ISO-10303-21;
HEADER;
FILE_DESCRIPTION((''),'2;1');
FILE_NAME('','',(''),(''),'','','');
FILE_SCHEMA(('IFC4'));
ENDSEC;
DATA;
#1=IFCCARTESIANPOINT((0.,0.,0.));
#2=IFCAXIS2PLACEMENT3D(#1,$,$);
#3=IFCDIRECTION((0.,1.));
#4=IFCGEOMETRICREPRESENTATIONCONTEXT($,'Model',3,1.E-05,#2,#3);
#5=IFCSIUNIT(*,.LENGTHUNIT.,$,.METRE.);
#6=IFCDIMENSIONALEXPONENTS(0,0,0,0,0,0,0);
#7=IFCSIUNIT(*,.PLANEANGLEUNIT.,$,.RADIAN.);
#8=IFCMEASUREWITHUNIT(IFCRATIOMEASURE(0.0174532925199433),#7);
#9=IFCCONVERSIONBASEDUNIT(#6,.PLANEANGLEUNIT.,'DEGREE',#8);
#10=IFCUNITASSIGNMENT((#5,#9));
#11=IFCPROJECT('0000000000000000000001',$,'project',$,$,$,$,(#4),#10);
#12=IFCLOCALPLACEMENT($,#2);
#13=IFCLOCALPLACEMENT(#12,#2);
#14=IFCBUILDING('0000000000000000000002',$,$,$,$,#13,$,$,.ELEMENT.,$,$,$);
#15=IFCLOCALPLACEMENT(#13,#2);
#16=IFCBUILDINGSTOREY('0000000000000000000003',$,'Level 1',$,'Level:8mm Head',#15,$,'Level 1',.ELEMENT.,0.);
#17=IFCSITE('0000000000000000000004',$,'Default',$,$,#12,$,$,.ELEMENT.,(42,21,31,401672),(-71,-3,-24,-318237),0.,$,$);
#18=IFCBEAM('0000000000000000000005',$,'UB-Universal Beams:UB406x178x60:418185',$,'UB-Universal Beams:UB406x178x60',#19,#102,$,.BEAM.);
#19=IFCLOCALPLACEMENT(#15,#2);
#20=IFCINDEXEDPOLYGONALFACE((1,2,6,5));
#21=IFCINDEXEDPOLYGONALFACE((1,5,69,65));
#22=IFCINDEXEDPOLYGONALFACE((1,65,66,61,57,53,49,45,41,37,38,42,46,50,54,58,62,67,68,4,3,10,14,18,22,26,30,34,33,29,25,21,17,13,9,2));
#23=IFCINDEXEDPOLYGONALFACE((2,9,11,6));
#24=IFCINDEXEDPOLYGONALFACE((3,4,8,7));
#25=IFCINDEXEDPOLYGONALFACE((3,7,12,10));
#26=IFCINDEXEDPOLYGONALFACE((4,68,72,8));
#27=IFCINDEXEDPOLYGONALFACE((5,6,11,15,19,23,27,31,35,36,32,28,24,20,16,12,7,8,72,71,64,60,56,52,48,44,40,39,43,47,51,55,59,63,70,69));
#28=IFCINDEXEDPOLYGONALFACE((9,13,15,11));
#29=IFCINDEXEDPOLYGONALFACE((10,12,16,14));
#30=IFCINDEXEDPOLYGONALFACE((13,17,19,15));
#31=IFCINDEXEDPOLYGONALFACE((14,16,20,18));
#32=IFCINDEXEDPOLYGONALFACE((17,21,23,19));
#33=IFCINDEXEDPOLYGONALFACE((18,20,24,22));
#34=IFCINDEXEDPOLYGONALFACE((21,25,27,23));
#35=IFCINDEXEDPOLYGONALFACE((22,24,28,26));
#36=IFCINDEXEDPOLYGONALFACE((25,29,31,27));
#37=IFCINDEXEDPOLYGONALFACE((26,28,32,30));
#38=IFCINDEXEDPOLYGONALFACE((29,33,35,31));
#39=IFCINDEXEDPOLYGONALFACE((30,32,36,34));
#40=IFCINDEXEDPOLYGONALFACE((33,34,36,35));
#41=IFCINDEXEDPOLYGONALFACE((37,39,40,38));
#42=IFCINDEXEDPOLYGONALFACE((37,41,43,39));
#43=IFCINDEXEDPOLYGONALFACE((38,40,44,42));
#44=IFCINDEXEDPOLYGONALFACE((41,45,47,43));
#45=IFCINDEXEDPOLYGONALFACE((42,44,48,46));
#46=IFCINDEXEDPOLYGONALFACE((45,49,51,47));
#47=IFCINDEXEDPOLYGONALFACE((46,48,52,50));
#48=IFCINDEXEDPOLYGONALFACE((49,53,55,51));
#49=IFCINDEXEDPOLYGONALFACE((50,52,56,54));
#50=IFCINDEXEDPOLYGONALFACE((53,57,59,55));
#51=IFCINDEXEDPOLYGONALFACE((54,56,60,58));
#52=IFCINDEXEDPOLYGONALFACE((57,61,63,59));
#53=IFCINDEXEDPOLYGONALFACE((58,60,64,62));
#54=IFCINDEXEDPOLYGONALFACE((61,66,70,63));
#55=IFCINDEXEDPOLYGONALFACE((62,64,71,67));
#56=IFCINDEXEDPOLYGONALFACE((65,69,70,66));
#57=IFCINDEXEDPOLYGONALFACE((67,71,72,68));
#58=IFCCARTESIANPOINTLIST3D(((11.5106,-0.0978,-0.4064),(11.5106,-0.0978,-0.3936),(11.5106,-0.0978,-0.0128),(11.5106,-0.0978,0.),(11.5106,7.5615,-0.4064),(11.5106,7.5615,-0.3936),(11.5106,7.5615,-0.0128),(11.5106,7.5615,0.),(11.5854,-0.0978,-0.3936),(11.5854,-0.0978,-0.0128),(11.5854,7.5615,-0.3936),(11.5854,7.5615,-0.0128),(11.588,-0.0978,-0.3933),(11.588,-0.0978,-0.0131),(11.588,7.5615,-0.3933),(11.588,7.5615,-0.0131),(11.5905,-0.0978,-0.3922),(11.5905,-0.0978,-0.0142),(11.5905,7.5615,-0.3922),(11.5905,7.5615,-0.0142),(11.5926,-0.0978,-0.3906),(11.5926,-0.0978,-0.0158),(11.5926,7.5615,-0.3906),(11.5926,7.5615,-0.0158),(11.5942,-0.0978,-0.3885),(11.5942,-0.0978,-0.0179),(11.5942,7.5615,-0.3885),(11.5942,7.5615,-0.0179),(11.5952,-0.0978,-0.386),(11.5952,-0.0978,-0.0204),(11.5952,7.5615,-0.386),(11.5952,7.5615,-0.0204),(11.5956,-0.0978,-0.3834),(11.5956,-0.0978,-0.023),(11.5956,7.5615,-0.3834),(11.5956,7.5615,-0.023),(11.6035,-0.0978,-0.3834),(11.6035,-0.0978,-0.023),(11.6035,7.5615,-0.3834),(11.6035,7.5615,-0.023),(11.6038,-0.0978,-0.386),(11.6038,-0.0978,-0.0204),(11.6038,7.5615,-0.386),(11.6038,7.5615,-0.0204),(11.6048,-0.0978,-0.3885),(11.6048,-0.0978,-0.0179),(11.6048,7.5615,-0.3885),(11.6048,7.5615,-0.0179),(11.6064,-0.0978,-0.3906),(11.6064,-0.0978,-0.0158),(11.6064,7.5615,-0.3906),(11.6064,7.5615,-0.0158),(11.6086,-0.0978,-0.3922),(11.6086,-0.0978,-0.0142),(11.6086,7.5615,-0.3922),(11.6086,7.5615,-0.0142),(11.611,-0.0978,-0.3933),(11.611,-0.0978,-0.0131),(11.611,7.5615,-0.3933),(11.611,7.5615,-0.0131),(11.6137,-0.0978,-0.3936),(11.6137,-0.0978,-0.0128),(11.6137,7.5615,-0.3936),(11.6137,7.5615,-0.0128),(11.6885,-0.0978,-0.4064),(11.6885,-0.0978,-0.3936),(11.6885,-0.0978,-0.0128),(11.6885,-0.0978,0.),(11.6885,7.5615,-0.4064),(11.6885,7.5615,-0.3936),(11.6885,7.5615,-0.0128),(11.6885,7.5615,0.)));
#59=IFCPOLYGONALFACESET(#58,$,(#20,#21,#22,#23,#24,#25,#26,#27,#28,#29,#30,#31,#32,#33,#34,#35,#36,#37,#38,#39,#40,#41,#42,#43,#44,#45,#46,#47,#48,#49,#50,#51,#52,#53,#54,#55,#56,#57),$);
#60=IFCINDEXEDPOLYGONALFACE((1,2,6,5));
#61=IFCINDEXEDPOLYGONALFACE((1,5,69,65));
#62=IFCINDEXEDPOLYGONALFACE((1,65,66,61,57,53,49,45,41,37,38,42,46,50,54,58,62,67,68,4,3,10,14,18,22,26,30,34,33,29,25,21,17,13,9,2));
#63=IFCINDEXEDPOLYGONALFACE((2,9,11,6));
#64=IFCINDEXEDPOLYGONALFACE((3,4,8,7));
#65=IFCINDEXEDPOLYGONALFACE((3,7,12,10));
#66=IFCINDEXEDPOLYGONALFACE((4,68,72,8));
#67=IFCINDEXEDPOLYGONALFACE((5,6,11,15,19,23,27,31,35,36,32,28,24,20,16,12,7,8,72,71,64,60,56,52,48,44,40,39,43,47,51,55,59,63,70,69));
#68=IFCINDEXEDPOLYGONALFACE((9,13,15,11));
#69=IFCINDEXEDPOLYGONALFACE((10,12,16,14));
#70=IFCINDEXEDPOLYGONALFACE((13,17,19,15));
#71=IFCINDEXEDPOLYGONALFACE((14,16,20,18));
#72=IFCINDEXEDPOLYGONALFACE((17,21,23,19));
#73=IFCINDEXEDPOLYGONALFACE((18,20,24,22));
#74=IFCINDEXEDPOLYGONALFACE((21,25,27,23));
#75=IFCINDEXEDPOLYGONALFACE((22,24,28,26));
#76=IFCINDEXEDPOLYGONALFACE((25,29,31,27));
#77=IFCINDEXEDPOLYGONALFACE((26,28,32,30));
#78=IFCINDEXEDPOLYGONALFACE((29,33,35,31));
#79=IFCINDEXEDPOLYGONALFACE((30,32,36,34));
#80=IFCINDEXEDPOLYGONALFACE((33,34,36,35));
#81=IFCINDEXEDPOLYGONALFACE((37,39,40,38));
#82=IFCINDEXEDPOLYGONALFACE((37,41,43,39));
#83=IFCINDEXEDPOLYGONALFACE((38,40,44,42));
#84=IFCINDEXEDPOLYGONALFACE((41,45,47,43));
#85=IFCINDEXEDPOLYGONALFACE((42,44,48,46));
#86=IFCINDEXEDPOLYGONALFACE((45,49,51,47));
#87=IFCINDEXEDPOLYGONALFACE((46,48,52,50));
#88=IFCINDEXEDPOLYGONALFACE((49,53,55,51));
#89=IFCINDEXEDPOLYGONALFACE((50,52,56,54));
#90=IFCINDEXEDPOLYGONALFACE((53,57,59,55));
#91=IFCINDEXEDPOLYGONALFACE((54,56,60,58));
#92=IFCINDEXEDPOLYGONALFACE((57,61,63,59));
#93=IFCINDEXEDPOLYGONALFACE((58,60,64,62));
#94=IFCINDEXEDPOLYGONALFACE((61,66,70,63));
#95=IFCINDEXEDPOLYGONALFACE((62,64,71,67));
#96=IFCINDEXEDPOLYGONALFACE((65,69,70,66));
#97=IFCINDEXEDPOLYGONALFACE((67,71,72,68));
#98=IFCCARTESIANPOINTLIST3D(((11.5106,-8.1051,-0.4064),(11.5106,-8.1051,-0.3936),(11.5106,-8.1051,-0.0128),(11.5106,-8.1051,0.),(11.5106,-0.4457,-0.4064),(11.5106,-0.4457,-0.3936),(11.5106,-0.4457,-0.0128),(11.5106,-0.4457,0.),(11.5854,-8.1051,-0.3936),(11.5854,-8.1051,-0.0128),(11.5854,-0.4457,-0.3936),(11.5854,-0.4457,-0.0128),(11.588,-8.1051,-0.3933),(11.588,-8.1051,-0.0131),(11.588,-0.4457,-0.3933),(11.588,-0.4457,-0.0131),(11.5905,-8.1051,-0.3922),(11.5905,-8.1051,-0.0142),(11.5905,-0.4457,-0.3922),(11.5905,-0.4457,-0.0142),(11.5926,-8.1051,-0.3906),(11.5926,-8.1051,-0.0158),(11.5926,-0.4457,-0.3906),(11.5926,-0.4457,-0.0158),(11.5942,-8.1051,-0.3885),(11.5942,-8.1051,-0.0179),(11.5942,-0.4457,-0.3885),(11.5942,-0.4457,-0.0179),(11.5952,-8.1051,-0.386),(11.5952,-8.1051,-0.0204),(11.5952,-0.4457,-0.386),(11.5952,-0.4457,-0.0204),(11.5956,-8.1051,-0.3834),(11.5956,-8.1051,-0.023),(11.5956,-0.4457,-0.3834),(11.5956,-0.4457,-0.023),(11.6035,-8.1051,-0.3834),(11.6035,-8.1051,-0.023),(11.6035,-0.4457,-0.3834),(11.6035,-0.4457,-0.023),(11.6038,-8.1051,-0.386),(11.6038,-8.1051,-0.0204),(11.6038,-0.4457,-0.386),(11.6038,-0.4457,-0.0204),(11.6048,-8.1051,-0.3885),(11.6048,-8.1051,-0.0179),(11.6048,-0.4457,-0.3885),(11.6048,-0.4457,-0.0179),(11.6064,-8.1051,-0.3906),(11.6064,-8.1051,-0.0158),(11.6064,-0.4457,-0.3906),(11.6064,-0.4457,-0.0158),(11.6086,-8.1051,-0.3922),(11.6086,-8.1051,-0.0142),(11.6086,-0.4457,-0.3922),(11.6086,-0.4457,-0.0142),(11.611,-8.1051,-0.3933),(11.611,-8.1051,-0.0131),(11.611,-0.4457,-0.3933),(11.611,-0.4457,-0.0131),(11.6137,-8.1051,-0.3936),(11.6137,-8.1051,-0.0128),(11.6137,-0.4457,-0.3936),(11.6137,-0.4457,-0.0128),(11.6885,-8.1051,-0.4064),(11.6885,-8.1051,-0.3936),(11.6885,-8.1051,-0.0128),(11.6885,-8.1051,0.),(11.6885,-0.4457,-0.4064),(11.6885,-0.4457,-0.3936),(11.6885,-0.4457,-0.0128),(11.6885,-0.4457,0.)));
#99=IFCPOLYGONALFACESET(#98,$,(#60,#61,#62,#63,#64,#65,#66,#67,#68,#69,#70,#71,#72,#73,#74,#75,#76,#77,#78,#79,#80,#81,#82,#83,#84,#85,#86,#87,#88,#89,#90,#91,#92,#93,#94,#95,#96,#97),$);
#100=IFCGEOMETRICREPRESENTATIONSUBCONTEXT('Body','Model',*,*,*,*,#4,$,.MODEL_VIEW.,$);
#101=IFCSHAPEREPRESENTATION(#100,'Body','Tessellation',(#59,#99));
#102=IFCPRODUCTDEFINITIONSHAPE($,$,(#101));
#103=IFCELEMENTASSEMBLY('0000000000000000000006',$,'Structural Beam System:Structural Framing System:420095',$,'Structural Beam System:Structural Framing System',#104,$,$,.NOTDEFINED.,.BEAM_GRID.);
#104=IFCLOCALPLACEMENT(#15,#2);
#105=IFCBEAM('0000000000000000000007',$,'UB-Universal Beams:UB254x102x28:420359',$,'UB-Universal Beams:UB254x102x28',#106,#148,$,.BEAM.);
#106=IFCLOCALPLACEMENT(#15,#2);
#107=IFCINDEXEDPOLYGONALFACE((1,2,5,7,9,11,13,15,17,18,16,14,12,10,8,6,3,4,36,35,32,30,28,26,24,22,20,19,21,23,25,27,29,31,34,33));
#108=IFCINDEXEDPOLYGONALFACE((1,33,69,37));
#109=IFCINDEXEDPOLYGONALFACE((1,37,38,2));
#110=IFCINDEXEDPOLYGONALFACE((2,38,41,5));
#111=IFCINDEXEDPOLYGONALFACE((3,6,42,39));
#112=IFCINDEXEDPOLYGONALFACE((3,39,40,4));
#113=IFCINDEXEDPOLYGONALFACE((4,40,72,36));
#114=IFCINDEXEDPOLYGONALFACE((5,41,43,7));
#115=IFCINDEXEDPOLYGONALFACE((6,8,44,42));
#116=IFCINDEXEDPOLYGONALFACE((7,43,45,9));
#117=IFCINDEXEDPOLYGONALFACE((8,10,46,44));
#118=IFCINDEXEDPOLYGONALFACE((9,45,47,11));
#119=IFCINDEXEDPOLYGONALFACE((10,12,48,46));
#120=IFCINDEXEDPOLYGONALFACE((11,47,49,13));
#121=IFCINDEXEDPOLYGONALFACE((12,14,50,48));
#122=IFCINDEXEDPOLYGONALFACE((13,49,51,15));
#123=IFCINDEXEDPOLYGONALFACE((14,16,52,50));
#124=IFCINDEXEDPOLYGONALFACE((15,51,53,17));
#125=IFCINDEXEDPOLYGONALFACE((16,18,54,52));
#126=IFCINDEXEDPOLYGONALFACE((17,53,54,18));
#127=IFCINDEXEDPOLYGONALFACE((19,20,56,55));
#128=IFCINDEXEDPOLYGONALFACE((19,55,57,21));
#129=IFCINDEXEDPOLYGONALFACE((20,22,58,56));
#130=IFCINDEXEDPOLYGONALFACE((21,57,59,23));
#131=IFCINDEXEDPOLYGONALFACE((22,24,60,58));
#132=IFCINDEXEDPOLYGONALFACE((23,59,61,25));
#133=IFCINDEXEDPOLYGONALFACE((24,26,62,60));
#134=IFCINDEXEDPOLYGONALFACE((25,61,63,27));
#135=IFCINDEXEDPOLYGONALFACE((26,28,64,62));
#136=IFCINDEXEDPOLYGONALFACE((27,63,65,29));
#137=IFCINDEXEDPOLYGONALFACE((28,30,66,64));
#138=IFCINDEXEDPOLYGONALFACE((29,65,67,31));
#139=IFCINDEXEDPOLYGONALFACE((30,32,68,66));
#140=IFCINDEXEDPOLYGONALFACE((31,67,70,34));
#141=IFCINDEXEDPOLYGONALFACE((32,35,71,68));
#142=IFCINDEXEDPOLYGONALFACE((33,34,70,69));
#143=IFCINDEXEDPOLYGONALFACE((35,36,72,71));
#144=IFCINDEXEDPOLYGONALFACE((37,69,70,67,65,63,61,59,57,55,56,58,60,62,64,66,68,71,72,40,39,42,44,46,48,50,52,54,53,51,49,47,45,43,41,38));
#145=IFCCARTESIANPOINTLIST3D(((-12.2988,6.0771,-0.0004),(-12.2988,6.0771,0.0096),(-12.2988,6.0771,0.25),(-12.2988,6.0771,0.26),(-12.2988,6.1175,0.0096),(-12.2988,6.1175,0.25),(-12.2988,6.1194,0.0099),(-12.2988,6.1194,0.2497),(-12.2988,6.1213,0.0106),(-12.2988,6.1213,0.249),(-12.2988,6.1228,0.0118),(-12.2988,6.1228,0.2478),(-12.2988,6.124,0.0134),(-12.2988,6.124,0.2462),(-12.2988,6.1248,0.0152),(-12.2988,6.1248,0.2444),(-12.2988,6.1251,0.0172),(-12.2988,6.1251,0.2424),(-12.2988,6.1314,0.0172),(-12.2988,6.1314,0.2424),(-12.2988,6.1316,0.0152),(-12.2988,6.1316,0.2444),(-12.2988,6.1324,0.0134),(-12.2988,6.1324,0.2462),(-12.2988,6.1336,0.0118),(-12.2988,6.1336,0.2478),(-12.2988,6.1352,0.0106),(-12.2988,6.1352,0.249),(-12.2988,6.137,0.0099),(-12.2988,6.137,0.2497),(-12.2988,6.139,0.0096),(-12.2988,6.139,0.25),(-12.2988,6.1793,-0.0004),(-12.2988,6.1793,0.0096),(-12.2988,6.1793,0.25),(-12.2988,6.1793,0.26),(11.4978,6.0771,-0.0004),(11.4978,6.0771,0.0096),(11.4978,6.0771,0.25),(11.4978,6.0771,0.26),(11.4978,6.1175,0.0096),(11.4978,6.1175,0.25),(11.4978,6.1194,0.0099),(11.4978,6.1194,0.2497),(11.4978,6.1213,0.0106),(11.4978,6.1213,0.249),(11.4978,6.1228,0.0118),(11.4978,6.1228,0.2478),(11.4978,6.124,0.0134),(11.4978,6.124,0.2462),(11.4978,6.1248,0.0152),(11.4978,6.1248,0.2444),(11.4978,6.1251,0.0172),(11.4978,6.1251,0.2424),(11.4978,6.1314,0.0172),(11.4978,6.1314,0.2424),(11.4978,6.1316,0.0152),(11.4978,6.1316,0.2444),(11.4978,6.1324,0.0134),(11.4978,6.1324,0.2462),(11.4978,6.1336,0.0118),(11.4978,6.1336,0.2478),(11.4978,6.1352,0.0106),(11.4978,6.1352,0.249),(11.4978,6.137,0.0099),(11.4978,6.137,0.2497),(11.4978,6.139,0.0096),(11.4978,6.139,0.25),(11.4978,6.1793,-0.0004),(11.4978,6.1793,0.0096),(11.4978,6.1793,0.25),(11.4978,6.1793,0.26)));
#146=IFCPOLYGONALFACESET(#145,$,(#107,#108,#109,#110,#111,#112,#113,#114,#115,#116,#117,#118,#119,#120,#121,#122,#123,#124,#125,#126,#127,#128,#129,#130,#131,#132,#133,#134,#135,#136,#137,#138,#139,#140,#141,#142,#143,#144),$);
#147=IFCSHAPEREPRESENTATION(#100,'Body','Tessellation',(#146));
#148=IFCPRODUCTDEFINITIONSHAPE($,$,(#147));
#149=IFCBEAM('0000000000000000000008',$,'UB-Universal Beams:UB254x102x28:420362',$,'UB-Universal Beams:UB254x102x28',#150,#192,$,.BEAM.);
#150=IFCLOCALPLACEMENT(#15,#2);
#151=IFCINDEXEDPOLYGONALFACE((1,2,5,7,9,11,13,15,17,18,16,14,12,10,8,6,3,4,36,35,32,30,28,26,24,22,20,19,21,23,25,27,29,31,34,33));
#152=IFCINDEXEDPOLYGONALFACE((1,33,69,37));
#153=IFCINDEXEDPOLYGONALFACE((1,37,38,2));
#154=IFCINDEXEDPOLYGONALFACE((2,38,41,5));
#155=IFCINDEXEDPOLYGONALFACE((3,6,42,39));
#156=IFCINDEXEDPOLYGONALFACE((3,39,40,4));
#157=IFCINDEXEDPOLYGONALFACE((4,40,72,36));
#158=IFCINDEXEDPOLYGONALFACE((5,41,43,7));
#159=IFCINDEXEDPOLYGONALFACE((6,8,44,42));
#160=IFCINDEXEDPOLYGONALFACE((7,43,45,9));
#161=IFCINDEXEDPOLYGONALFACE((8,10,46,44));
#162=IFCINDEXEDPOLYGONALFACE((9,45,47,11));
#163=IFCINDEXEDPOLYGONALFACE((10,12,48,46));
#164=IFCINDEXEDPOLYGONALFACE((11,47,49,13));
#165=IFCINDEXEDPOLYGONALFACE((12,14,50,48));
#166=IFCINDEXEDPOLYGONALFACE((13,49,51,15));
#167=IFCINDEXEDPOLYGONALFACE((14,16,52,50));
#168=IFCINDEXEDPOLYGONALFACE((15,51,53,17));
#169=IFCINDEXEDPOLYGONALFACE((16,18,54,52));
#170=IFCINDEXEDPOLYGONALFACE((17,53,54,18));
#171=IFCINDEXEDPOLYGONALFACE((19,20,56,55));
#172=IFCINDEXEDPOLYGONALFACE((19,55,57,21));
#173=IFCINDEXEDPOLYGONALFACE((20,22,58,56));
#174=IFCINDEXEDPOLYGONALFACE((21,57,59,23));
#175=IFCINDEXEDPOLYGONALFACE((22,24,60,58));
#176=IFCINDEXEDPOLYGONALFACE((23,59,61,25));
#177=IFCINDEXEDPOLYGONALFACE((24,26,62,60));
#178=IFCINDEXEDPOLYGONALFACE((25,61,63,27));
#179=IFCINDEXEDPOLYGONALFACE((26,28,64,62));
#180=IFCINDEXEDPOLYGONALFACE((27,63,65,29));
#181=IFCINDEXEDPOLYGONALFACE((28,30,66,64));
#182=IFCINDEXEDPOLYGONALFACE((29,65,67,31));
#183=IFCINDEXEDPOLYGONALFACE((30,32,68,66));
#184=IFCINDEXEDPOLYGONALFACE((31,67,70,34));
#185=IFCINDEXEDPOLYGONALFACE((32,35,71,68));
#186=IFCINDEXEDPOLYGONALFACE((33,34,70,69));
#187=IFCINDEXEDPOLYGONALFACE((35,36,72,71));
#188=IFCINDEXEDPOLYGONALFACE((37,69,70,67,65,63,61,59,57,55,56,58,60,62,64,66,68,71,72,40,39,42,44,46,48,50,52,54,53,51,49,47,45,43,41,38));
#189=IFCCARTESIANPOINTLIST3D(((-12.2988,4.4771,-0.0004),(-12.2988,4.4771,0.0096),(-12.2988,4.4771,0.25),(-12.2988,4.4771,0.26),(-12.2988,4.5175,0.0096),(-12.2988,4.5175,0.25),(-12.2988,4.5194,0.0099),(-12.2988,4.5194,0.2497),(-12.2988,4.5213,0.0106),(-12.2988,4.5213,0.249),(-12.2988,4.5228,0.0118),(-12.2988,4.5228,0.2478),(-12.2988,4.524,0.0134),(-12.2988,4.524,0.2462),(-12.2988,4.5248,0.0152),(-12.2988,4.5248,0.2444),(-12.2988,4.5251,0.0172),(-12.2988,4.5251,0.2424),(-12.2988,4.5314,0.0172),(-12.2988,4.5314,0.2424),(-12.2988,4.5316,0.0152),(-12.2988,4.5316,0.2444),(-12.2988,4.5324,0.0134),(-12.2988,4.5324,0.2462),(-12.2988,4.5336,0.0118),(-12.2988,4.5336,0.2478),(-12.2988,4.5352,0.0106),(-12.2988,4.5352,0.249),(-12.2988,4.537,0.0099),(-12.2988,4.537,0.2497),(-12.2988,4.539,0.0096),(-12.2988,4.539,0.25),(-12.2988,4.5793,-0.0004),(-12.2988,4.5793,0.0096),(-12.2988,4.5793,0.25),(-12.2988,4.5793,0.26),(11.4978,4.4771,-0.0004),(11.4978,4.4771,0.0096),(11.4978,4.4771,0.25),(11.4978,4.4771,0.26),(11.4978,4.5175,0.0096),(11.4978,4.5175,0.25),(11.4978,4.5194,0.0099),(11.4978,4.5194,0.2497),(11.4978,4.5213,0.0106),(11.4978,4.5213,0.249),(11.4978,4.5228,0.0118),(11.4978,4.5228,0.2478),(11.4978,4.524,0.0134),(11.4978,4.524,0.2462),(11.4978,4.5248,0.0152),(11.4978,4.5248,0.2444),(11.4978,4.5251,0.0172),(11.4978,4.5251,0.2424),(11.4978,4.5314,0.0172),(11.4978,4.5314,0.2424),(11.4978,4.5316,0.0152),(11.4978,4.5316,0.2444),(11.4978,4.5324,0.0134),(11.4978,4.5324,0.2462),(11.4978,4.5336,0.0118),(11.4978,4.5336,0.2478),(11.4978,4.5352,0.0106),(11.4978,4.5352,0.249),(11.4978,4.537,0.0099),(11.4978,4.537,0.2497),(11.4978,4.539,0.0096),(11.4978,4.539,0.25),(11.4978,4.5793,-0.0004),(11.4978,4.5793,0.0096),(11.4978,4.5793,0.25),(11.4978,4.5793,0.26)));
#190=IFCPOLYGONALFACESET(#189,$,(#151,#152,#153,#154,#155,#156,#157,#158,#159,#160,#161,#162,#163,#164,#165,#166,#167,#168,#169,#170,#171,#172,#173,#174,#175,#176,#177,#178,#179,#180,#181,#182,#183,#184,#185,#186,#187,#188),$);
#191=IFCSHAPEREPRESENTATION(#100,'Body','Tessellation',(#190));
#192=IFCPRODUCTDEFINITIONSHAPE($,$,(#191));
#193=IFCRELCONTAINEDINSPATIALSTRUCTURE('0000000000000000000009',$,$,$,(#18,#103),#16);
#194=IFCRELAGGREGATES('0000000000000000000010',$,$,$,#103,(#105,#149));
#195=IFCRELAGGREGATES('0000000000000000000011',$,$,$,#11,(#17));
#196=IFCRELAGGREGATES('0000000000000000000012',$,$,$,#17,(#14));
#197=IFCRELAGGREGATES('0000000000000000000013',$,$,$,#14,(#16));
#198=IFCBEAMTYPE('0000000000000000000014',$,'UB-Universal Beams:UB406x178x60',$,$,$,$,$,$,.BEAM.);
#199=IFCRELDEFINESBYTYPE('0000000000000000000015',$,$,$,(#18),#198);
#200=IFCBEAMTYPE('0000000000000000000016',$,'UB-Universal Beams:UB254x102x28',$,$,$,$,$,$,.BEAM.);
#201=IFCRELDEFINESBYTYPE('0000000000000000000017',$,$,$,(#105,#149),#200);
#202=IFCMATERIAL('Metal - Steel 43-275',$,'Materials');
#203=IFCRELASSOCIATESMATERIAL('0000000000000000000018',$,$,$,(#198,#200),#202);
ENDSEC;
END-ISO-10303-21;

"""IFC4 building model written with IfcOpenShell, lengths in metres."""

from ifc_helpers import new_model, entity, si_unit, converted_unit, direction, frame, frame_2d, origin, place, context, subcontext, project, spatial, i_section, extrude, source, transform, mapped, material, material_profile, profile_set, type_object, type_shapes, element, aggregate, save


model = new_model("IFC4")

# Units and contexts
model_context = context("Model", 3, precision=1e-05, world=origin(), true_north=direction((0.0, 1.0)))
body_context = subcontext(model_context, "Body", "Model", "MODEL_VIEW")
ifc_project = project(units=[si_unit("LENGTHUNIT", "METRE"), converted_unit("PLANEANGLEUNIT", "DEGREE", entity("IfcRatioMeasure", 0.0174532925199433), si_unit("PLANEANGLEUNIT", "RADIAN"), dimensions=[0, 0, 0, 0, 0, 0, 0])], contexts=[model_context])

# Site, building, storey
site_placement = place(None, origin())
site = spatial("IfcSite", under=ifc_project, at=site_placement, Name="Default", CompositionType="ELEMENT", RefLatitude=(42, 21, 31, 401672), RefLongitude=(-71, -3, -24, -318237), RefElevation=0.0)
building_placement = place(site_placement, origin())
building = spatial("IfcBuilding", under=site, at=building_placement, CompositionType="ELEMENT")
storey_placement = place(building_placement, origin())
storey = spatial("IfcBuildingStorey", under=building, at=storey_placement, Name="Level 1", ObjectType="Level:8mm Head", LongName="Level 1", CompositionType="ELEMENT", Elevation=0.0)

# Beam
ifc_material_1 = material(Name="Metal - Steel 43-275", Category="Materials")
ifc_material_profile_1 = material_profile(ifc_material_1, i_section(OverallWidth=0.1779, OverallDepth=0.4064, WebThickness=0.0079, FlangeThickness=0.0128, FilletRadius=0.0102, at=frame_2d((0.0, 0.0), x_axis=(0.0, 1.0))), Name="UB406x178x60")
ifc_profile_set_1 = profile_set([ifc_material_profile_1], Name="UB406x178x60")
beam_type_1 = type_object("IfcBeamType", Name="UB-Universal Beams:UB406x178x60", PredefinedType="BEAM", material=ifc_profile_set_1)
shared_shape_1 = source(origin(), body_context, "Body", "SweptSolid", [
    extrude(i_section(OverallWidth=0.1779, OverallDepth=0.4064, WebThickness=0.0079, FlangeThickness=0.0128, FilletRadius=0.0102, at=frame_2d((0.0, 0.0), x_axis=(1.0, 0.0))), frame((11.5995, -0.0978, -0.2032), z_axis=(0.0, 1.0, 0.0), x_axis=(-1.0, 0.0, 0.0)), (0.0, 0.0, 1.0), 7.6593),
    extrude(i_section(OverallWidth=0.1779, OverallDepth=0.4064, WebThickness=0.0079, FlangeThickness=0.0128, FilletRadius=0.0102, at=frame_2d((0.0, 0.0), x_axis=(1.0, 0.0))), frame((11.5995, -8.1051, -0.2032), z_axis=(0.0, 1.0, 0.0), x_axis=(-1.0, 0.0, 0.0)), (0.0, 0.0, 1.0), 7.6593),
])
type_shapes(beam_type_1, [shared_shape_1])
beam_1_placement = place(storey_placement, origin())
element("IfcBeam", 1, at=beam_1_placement, inside=storey, type_object=beam_type_1, Name="UB-Universal Beams:UB406x178x60:418185", ObjectType="UB-Universal Beams:UB406x178x60", PredefinedType="BEAM", context=body_context, shape_type="MappedRepresentation", body=[
    mapped(shared_shape_1, transform((0.0, 0.0, 0.0), scale=1.0)),
])

# Element assembly, beams
assembly_placement = place(storey_placement, origin())
assembly = element("IfcElementAssembly", 2, at=assembly_placement, inside=storey, Name="Structural Beam System:Structural Framing System:420095", ObjectType="Structural Beam System:Structural Framing System", AssemblyPlace="NOTDEFINED", PredefinedType="BEAM_GRID")
ifc_material_profile_2 = material_profile(ifc_material_1, i_section(OverallWidth=0.1022, OverallDepth=0.2604, WebThickness=0.0063, FlangeThickness=0.01, FilletRadius=0.0076, at=frame_2d((0.0, 0.0), x_axis=(0.0, 1.0))), Name="UB254x102x28")
ifc_profile_set_2 = profile_set([ifc_material_profile_2], Name="UB254x102x28")
beam_type_2 = type_object("IfcBeamType", Name="UB-Universal Beams:UB254x102x28", PredefinedType="BEAM", material=ifc_profile_set_2)
shared_shape_2 = source(origin(), body_context, "Body", "SweptSolid", [
    extrude(i_section(OverallWidth=0.1022, OverallDepth=0.2604, WebThickness=0.0063, FlangeThickness=0.01, FilletRadius=0.0076, at=frame_2d((0.0, 0.0), x_axis=(0.0, 1.0))), frame((-11.8983, 0.0, 0.0), z_axis=(1.0, 0.0, 0.0), x_axis=(0.0, 0.0, -1.0)), (0.0, 0.0, 1.0), 23.7966),
])
type_shapes(beam_type_2, [shared_shape_2])
beam_2_placement = place(assembly_placement, frame((-0.4005, 6.1282, 0.1298)))
beam_2 = element("IfcBeam", 3, at=beam_2_placement, type_object=beam_type_2, Name="UB-Universal Beams:UB254x102x28:420359", ObjectType="UB-Universal Beams:UB254x102x28", PredefinedType="BEAM", context=body_context, shape_type="MappedRepresentation", body=[
    mapped(shared_shape_2, transform((0.0, 0.0, 0.0), scale=1.0)),
])
beam_3_placement = place(assembly_placement, frame((-0.4005, 4.5282, 0.1298)))
beam_3 = element("IfcBeam", 4, at=beam_3_placement, type_object=beam_type_2, Name="UB-Universal Beams:UB254x102x28:420362", ObjectType="UB-Universal Beams:UB254x102x28", PredefinedType="BEAM", context=body_context, shape_type="MappedRepresentation", body=[
    mapped(shared_shape_2, transform((0.0, 0.0, 0.0), scale=1.0)),
])
aggregate(assembly, [beam_2, beam_3])

save(model, "model.ifc")
